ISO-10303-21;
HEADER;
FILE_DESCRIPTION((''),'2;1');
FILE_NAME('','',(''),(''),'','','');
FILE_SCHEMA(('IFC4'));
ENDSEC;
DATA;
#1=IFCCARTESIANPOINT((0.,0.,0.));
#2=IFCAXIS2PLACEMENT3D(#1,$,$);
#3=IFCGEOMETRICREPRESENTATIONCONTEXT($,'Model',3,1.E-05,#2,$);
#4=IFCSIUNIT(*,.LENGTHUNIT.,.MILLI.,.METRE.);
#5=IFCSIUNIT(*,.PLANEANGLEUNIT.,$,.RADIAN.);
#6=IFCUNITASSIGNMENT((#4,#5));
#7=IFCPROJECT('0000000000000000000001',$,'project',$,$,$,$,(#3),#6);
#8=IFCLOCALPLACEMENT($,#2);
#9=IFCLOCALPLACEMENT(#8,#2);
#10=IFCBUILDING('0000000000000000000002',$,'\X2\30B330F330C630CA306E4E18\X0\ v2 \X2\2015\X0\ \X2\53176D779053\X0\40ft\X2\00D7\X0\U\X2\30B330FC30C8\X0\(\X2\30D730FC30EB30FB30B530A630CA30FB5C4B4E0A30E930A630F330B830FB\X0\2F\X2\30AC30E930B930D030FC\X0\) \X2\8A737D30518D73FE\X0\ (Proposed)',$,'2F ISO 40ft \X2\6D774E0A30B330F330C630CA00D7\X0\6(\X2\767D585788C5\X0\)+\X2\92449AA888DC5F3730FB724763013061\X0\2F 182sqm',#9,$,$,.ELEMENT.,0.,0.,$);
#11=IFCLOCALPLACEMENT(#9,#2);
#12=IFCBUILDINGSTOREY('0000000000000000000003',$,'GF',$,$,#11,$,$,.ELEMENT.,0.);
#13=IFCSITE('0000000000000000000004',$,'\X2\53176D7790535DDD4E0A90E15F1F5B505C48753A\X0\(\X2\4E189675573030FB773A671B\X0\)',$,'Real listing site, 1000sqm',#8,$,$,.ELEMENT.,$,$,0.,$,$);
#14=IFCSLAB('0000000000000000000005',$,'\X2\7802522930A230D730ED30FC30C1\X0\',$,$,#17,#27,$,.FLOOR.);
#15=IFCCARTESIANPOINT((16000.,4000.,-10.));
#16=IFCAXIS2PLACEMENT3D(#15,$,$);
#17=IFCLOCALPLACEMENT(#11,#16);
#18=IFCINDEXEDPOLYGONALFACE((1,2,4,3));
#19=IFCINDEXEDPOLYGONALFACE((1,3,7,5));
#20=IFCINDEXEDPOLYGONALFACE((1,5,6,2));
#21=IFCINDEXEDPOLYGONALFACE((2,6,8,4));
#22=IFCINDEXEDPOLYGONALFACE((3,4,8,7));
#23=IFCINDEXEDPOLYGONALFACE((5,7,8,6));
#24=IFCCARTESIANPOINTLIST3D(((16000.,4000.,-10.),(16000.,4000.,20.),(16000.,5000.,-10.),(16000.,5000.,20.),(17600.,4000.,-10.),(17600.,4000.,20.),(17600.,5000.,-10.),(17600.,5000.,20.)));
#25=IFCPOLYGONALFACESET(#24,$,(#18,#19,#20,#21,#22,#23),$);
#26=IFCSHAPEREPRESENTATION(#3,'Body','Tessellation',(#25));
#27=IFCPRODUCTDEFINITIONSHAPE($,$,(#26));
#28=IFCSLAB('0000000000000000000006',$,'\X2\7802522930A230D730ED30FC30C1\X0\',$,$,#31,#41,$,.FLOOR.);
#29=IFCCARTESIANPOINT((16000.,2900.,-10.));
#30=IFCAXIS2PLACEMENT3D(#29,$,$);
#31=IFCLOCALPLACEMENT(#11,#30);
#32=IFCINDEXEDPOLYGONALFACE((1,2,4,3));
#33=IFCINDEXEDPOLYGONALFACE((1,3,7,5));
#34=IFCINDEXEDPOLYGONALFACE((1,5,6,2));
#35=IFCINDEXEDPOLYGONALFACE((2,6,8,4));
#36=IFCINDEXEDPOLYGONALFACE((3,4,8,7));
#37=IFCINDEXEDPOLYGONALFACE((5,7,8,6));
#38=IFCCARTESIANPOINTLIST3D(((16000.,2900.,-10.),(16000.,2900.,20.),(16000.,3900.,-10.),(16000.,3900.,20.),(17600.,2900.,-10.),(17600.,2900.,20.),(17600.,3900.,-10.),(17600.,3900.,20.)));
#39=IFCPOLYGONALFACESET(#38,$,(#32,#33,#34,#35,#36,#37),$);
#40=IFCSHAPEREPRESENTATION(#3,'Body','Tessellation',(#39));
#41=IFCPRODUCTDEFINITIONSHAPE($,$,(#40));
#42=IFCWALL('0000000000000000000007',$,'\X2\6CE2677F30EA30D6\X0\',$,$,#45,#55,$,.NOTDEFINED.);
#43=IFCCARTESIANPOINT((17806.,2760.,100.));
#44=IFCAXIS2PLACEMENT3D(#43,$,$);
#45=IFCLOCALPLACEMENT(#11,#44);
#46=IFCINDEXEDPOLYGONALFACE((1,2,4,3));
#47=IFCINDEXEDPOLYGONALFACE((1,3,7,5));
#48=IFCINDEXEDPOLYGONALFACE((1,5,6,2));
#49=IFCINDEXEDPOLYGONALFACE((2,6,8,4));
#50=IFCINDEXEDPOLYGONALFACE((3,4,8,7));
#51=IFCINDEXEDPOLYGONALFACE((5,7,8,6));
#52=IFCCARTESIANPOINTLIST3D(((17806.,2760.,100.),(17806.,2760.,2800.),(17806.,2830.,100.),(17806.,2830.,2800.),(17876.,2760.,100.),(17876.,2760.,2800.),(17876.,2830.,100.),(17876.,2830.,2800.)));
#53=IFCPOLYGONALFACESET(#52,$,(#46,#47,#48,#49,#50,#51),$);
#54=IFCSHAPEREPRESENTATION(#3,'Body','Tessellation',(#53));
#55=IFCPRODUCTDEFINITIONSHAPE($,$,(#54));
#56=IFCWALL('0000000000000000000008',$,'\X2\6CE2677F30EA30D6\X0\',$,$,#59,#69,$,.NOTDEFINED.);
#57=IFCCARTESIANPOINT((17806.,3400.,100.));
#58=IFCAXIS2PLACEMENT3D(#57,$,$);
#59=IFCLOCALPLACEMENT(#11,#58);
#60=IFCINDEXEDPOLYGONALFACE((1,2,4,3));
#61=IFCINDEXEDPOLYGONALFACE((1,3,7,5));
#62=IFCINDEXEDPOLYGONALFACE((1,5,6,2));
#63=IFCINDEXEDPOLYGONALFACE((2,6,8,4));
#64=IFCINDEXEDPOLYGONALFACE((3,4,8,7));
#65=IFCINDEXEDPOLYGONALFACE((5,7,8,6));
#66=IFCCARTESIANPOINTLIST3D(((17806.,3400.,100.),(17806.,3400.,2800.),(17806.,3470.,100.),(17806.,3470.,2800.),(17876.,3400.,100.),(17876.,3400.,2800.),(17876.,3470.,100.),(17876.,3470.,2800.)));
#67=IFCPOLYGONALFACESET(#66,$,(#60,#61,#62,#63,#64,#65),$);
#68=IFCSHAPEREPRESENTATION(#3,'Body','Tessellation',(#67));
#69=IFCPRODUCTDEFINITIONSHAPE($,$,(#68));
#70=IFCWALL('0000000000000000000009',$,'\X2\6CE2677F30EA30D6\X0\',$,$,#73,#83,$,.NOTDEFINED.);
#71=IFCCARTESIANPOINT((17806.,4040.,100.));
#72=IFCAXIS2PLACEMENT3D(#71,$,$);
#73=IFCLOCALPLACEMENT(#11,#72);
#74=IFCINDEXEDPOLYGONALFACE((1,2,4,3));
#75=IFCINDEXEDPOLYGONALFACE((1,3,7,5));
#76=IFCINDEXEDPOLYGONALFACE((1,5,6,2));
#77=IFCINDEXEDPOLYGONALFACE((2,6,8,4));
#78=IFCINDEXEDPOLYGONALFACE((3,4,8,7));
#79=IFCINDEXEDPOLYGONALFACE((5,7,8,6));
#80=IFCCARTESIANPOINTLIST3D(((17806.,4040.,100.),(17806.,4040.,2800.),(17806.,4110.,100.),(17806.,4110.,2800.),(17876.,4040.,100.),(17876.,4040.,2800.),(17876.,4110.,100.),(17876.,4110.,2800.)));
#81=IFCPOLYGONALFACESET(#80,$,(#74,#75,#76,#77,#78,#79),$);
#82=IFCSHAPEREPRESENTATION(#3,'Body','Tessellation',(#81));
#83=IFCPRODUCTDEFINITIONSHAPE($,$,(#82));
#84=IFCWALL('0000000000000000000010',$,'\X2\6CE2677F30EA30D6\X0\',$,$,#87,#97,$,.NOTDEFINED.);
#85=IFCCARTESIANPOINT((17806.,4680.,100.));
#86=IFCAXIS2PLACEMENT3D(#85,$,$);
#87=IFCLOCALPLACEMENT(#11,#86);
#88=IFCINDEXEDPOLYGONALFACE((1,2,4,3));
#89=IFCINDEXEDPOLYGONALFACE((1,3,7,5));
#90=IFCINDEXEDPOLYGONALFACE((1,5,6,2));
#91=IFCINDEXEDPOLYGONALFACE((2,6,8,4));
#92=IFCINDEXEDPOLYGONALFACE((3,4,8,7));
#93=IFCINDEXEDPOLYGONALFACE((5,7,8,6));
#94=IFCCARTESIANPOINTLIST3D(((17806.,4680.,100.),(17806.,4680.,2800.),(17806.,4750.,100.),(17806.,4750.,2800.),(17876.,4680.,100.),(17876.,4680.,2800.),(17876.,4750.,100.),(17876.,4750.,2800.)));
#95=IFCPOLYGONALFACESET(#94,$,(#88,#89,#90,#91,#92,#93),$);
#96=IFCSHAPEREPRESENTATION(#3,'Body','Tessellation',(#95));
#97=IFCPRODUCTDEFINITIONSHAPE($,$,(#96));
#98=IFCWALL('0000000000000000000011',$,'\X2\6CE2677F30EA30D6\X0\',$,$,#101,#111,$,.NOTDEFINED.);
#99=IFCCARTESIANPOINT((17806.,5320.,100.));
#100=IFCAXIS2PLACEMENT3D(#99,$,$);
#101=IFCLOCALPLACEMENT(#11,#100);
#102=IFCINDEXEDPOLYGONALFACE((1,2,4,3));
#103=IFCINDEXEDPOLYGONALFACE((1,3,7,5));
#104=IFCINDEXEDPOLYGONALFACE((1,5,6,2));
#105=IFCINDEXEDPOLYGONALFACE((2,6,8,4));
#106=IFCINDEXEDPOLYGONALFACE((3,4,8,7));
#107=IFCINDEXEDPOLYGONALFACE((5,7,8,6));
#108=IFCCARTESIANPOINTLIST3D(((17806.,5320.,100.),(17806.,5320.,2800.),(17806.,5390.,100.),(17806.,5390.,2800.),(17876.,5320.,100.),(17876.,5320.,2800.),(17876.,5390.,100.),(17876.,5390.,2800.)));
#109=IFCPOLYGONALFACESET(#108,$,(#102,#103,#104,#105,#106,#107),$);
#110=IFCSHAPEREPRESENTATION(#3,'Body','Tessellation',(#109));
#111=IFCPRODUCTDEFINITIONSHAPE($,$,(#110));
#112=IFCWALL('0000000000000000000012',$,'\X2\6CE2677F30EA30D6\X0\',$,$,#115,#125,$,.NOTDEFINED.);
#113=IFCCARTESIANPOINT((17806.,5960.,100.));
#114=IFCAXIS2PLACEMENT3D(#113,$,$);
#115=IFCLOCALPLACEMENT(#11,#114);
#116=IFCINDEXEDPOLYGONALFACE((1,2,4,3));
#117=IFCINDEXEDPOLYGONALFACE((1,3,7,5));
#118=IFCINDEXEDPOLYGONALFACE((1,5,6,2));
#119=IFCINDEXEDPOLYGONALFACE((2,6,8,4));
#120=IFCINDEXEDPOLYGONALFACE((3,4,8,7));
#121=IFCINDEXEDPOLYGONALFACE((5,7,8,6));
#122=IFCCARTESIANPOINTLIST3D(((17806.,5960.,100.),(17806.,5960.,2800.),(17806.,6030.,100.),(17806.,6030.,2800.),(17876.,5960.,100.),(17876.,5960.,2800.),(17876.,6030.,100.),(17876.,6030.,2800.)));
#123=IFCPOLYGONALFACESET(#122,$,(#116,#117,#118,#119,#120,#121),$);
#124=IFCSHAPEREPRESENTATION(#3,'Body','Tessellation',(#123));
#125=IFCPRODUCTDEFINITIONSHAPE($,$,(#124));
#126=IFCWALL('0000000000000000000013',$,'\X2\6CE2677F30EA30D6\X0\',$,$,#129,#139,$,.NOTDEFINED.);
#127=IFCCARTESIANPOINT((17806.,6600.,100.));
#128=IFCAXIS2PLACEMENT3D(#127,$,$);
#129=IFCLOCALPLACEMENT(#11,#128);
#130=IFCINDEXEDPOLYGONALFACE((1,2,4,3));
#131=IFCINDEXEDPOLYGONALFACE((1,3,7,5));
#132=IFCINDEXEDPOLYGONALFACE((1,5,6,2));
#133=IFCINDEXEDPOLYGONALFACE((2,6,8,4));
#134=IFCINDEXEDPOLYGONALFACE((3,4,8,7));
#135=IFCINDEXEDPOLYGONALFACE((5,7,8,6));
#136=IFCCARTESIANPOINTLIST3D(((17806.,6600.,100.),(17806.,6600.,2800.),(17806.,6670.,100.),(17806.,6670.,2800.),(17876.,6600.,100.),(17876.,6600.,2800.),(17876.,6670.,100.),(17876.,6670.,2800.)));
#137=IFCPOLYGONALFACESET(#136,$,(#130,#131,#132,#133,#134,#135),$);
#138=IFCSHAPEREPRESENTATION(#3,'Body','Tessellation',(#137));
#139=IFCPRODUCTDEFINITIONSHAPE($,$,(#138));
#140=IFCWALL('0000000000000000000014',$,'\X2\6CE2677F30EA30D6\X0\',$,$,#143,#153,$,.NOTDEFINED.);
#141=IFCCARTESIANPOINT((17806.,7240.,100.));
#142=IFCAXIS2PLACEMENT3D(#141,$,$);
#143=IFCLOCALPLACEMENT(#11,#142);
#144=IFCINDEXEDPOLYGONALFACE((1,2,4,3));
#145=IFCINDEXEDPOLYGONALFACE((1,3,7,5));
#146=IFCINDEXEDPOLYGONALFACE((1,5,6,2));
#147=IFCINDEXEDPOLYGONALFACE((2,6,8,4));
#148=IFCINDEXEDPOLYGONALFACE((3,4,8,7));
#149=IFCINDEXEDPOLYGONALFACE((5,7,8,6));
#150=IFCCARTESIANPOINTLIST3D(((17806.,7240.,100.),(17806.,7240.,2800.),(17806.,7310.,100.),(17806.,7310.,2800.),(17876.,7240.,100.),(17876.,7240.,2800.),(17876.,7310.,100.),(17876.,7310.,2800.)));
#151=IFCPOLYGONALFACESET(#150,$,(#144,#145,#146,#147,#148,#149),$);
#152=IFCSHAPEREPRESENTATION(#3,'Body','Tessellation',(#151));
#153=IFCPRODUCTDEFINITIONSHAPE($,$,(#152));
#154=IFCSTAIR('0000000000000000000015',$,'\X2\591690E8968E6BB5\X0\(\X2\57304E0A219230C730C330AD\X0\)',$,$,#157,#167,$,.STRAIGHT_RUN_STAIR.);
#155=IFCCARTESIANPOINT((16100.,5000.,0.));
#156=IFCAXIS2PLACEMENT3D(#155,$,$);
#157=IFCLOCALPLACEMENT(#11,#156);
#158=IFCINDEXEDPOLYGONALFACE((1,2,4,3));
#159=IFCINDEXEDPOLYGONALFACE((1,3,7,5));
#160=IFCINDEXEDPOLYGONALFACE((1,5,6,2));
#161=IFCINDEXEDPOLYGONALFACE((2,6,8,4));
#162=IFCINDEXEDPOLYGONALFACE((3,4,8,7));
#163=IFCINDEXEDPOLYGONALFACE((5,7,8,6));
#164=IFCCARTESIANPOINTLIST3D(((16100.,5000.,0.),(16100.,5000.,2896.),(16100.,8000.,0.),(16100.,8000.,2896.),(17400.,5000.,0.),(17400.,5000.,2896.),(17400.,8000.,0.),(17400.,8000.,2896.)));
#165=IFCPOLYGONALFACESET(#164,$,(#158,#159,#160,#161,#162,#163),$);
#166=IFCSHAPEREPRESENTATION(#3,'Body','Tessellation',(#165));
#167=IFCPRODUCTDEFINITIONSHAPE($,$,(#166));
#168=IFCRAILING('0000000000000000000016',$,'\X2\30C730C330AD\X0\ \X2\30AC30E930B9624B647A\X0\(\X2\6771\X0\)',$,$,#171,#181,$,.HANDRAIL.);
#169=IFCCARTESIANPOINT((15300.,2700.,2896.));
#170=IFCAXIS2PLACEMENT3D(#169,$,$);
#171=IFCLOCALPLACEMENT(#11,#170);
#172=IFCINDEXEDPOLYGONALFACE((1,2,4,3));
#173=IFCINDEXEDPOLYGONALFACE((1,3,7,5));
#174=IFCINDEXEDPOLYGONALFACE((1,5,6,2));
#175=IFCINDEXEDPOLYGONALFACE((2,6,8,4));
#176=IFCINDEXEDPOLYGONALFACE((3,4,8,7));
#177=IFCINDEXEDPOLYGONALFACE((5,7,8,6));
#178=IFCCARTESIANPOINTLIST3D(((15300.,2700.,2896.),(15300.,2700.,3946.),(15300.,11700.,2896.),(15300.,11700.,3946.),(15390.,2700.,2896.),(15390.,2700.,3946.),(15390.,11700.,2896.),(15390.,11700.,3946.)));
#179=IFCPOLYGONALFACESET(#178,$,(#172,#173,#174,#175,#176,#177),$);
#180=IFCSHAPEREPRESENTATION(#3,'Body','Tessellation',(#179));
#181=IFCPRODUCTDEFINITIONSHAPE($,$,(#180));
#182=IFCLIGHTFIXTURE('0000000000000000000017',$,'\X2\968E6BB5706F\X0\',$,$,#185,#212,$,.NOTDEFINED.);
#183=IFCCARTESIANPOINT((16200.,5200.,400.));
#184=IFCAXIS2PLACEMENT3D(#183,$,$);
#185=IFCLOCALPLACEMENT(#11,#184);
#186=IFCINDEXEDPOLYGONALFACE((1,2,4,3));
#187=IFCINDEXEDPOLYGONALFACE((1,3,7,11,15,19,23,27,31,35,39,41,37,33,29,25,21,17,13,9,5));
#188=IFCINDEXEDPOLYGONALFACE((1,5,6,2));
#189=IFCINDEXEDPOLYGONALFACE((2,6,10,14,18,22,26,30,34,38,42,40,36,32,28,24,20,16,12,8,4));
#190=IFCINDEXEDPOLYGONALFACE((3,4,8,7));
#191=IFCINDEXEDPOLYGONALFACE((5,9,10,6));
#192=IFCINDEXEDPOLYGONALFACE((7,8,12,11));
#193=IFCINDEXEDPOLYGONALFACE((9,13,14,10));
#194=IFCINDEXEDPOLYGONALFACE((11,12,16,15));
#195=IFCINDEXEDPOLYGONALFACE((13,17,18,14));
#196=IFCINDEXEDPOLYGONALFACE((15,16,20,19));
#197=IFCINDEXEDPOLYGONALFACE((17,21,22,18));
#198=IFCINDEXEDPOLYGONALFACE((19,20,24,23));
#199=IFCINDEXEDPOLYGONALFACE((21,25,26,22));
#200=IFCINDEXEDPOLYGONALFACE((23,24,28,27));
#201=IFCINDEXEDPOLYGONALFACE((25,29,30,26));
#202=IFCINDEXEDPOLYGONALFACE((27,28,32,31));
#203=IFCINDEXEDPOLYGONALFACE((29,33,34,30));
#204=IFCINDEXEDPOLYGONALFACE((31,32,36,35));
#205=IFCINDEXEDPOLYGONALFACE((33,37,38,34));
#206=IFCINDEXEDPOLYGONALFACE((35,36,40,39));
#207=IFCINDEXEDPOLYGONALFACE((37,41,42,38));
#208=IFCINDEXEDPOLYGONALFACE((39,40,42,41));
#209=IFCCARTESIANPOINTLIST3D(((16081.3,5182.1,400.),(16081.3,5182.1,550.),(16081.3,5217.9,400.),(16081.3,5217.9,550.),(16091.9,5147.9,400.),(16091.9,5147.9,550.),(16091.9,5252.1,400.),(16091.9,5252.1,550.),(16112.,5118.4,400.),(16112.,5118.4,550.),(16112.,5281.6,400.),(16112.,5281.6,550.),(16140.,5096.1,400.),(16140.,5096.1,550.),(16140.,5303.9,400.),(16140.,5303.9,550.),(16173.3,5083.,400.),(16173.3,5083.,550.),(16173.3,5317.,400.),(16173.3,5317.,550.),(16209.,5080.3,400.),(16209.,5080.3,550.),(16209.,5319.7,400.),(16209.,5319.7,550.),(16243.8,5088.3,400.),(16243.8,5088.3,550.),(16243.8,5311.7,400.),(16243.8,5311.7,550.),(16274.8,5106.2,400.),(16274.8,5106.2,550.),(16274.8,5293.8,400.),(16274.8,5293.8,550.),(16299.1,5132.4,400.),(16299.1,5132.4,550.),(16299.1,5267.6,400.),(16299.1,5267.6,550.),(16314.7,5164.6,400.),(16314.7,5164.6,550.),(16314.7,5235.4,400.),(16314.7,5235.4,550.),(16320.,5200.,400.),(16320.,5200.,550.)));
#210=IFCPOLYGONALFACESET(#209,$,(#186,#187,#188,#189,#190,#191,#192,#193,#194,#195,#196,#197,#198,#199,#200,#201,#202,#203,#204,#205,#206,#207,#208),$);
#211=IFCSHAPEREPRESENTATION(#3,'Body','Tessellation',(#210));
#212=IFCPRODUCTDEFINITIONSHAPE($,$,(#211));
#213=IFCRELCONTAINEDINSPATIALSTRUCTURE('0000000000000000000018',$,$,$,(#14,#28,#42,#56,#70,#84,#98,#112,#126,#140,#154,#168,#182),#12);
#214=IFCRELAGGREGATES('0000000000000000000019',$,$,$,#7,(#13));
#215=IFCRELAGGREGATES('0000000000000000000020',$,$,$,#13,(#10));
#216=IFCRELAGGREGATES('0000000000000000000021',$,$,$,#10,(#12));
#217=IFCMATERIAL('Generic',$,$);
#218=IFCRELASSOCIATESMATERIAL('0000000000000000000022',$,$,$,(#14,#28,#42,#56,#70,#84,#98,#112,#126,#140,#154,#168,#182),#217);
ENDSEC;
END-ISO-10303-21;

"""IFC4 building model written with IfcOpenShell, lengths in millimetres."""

from ifc_helpers import new_model, si_unit, frame, frame_2d, origin, origin_2d, place, context, project, spatial, rectangle, circle, extrude, material, element, save


model = new_model("IFC4")

# Units and contexts
model_context = context("Model", 3, precision=1e-05, world=origin())
ifc_project = project(units=[si_unit("LENGTHUNIT", "METRE", prefix="MILLI"), si_unit("PLANEANGLEUNIT", "RADIAN")], contexts=[model_context])

# Site, building, storey
site_placement = place(None, origin())
site = spatial("IfcSite", under=ifc_project, at=site_placement, Name="北海道川上郡弟子屈町(丘陵地・眺望)", ObjectType="Real listing site, 1000sqm", CompositionType="ELEMENT", RefElevation=0.0)
building_placement = place(site_placement, origin())
building = spatial("IfcBuilding", under=site, at=building_placement, Name="コンテナの丘 v2 ― 北海道40ft×Uコート(プール・サウナ・屋上ラウンジ・2Fガラスバー) 詳細再現 (Proposed)", ObjectType="2F ISO 40ft 海上コンテナ×6(白塗装)+鉄骨補強・片持ち2F 182sqm", CompositionType="ELEMENT", ElevationOfRefHeight=0.0, ElevationOfTerrain=0.0)
storey_placement = place(building_placement, origin())
storey = spatial("IfcBuildingStorey", under=building, at=storey_placement, Name="GF", CompositionType="ELEMENT", Elevation=0.0)

# Slabs
ifc_material = material(Name="Generic")
slab_1_placement = place(storey_placement, frame((16000.0, 4000.0, -10.0)))
element("IfcSlab", 1, at=slab_1_placement, inside=storey, material=ifc_material, Name="砂利アプローチ", PredefinedType="FLOOR", context=model_context, shape_type="SweptSolid", body=[
    extrude(rectangle(XDim=1600.0, YDim=1000.0, at=frame_2d((800.0, 500.0))), frame((16000.0, 4000.0, -10.0)), (0.0, 0.0, 1.0), 30.0),
])
slab_2_placement = place(storey_placement, frame((16000.0, 2900.0, -10.0)))
element("IfcSlab", 2, at=slab_2_placement, inside=storey, material=ifc_material, Name="砂利アプローチ", PredefinedType="FLOOR", context=model_context, shape_type="SweptSolid", body=[
    extrude(rectangle(XDim=1600.0, YDim=1000.0, at=frame_2d((800.0, 500.0))), frame((16000.0, 2900.0, -10.0)), (0.0, 0.0, 1.0), 30.0),
])

# Walls
wall_1_placement = place(storey_placement, frame((17806.0, 2760.0, 100.0)))
element("IfcWall", 3, at=wall_1_placement, inside=storey, material=ifc_material, Name="波板リブ", PredefinedType="NOTDEFINED", context=model_context, shape_type="SweptSolid", body=[
    extrude(rectangle(XDim=70.0, YDim=70.0, at=frame_2d((35.0, 35.0))), frame((17806.0, 2760.0, 100.0)), (0.0, 0.0, 1.0), 2700.0),
])
wall_2_placement = place(storey_placement, frame((17806.0, 3400.0, 100.0)))
element("IfcWall", 4, at=wall_2_placement, inside=storey, material=ifc_material, Name="波板リブ", PredefinedType="NOTDEFINED", context=model_context, shape_type="SweptSolid", body=[
    extrude(rectangle(XDim=70.0, YDim=70.0, at=frame_2d((35.0, 35.0))), frame((17806.0, 3400.0, 100.0)), (0.0, 0.0, 1.0), 2700.0),
])
wall_3_placement = place(storey_placement, frame((17806.0, 4040.0, 100.0)))
element("IfcWall", 5, at=wall_3_placement, inside=storey, material=ifc_material, Name="波板リブ", PredefinedType="NOTDEFINED", context=model_context, shape_type="SweptSolid", body=[
    extrude(rectangle(XDim=70.0, YDim=70.0, at=frame_2d((35.0, 35.0))), frame((17806.0, 4040.0, 100.0)), (0.0, 0.0, 1.0), 2700.0),
])
wall_4_placement = place(storey_placement, frame((17806.0, 4680.0, 100.0)))
element("IfcWall", 6, at=wall_4_placement, inside=storey, material=ifc_material, Name="波板リブ", PredefinedType="NOTDEFINED", context=model_context, shape_type="SweptSolid", body=[
    extrude(rectangle(XDim=70.0, YDim=70.0, at=frame_2d((35.0, 35.0))), frame((17806.0, 4680.0, 100.0)), (0.0, 0.0, 1.0), 2700.0),
])
wall_5_placement = place(storey_placement, frame((17806.0, 5320.0, 100.0)))
element("IfcWall", 7, at=wall_5_placement, inside=storey, material=ifc_material, Name="波板リブ", PredefinedType="NOTDEFINED", context=model_context, shape_type="SweptSolid", body=[
    extrude(rectangle(XDim=70.0, YDim=70.0, at=frame_2d((35.0, 35.0))), frame((17806.0, 5320.0, 100.0)), (0.0, 0.0, 1.0), 2700.0),
])
wall_6_placement = place(storey_placement, frame((17806.0, 5960.0, 100.0)))
element("IfcWall", 8, at=wall_6_placement, inside=storey, material=ifc_material, Name="波板リブ", PredefinedType="NOTDEFINED", context=model_context, shape_type="SweptSolid", body=[
    extrude(rectangle(XDim=70.0, YDim=70.0, at=frame_2d((35.0, 35.0))), frame((17806.0, 5960.0, 100.0)), (0.0, 0.0, 1.0), 2700.0),
])
wall_7_placement = place(storey_placement, frame((17806.0, 6600.0, 100.0)))
element("IfcWall", 9, at=wall_7_placement, inside=storey, material=ifc_material, Name="波板リブ", PredefinedType="NOTDEFINED", context=model_context, shape_type="SweptSolid", body=[
    extrude(rectangle(XDim=70.0, YDim=70.0, at=frame_2d((35.0, 35.0))), frame((17806.0, 6600.0, 100.0)), (0.0, 0.0, 1.0), 2700.0),
])
wall_8_placement = place(storey_placement, frame((17806.0, 7240.0, 100.0)))
element("IfcWall", 10, at=wall_8_placement, inside=storey, material=ifc_material, Name="波板リブ", PredefinedType="NOTDEFINED", context=model_context, shape_type="SweptSolid", body=[
    extrude(rectangle(XDim=70.0, YDim=70.0, at=frame_2d((35.0, 35.0))), frame((17806.0, 7240.0, 100.0)), (0.0, 0.0, 1.0), 2700.0),
])

# Stair
stair_placement = place(storey_placement, frame((16100.0, 5000.0, 0.0)))
element("IfcStair", 11, at=stair_placement, inside=storey, material=ifc_material, Name="外部階段(地上→デッキ)", PredefinedType="STRAIGHT_RUN_STAIR", context=model_context, shape_type="SweptSolid", body=[
    extrude(rectangle(XDim=1300.0, YDim=3000.0, at=frame_2d((650.0, 1500.0))), frame((16100.0, 5000.0, 0.0)), (0.0, 0.0, 1.0), 2896.0),
])

# Railing
railing_placement = place(storey_placement, frame((15300.0, 2700.0, 2896.0)))
element("IfcRailing", 12, at=railing_placement, inside=storey, material=ifc_material, Name="デッキ ガラス手摺(東)", PredefinedType="HANDRAIL", context=model_context, shape_type="SweptSolid", body=[
    extrude(rectangle(XDim=90.0, YDim=9000.0, at=frame_2d((45.0, 4500.0))), frame((15300.0, 2700.0, 2896.0)), (0.0, 0.0, 1.0), 1050.0),
])

# Light fixture
light_fixture_1_placement = place(storey_placement, frame((16200.0, 5200.0, 400.0)))
element("IfcLightFixture", 13, at=light_fixture_1_placement, inside=storey, material=ifc_material, Name="階段灯", PredefinedType="NOTDEFINED", context=model_context, shape_type="SweptSolid", body=[
    extrude(circle(Radius=120.0, at=origin_2d()), frame((16200.0, 5200.0, 400.0)), (0.0, 0.0, 1.0), 150.0),
])

save(model, "model.ifc")
